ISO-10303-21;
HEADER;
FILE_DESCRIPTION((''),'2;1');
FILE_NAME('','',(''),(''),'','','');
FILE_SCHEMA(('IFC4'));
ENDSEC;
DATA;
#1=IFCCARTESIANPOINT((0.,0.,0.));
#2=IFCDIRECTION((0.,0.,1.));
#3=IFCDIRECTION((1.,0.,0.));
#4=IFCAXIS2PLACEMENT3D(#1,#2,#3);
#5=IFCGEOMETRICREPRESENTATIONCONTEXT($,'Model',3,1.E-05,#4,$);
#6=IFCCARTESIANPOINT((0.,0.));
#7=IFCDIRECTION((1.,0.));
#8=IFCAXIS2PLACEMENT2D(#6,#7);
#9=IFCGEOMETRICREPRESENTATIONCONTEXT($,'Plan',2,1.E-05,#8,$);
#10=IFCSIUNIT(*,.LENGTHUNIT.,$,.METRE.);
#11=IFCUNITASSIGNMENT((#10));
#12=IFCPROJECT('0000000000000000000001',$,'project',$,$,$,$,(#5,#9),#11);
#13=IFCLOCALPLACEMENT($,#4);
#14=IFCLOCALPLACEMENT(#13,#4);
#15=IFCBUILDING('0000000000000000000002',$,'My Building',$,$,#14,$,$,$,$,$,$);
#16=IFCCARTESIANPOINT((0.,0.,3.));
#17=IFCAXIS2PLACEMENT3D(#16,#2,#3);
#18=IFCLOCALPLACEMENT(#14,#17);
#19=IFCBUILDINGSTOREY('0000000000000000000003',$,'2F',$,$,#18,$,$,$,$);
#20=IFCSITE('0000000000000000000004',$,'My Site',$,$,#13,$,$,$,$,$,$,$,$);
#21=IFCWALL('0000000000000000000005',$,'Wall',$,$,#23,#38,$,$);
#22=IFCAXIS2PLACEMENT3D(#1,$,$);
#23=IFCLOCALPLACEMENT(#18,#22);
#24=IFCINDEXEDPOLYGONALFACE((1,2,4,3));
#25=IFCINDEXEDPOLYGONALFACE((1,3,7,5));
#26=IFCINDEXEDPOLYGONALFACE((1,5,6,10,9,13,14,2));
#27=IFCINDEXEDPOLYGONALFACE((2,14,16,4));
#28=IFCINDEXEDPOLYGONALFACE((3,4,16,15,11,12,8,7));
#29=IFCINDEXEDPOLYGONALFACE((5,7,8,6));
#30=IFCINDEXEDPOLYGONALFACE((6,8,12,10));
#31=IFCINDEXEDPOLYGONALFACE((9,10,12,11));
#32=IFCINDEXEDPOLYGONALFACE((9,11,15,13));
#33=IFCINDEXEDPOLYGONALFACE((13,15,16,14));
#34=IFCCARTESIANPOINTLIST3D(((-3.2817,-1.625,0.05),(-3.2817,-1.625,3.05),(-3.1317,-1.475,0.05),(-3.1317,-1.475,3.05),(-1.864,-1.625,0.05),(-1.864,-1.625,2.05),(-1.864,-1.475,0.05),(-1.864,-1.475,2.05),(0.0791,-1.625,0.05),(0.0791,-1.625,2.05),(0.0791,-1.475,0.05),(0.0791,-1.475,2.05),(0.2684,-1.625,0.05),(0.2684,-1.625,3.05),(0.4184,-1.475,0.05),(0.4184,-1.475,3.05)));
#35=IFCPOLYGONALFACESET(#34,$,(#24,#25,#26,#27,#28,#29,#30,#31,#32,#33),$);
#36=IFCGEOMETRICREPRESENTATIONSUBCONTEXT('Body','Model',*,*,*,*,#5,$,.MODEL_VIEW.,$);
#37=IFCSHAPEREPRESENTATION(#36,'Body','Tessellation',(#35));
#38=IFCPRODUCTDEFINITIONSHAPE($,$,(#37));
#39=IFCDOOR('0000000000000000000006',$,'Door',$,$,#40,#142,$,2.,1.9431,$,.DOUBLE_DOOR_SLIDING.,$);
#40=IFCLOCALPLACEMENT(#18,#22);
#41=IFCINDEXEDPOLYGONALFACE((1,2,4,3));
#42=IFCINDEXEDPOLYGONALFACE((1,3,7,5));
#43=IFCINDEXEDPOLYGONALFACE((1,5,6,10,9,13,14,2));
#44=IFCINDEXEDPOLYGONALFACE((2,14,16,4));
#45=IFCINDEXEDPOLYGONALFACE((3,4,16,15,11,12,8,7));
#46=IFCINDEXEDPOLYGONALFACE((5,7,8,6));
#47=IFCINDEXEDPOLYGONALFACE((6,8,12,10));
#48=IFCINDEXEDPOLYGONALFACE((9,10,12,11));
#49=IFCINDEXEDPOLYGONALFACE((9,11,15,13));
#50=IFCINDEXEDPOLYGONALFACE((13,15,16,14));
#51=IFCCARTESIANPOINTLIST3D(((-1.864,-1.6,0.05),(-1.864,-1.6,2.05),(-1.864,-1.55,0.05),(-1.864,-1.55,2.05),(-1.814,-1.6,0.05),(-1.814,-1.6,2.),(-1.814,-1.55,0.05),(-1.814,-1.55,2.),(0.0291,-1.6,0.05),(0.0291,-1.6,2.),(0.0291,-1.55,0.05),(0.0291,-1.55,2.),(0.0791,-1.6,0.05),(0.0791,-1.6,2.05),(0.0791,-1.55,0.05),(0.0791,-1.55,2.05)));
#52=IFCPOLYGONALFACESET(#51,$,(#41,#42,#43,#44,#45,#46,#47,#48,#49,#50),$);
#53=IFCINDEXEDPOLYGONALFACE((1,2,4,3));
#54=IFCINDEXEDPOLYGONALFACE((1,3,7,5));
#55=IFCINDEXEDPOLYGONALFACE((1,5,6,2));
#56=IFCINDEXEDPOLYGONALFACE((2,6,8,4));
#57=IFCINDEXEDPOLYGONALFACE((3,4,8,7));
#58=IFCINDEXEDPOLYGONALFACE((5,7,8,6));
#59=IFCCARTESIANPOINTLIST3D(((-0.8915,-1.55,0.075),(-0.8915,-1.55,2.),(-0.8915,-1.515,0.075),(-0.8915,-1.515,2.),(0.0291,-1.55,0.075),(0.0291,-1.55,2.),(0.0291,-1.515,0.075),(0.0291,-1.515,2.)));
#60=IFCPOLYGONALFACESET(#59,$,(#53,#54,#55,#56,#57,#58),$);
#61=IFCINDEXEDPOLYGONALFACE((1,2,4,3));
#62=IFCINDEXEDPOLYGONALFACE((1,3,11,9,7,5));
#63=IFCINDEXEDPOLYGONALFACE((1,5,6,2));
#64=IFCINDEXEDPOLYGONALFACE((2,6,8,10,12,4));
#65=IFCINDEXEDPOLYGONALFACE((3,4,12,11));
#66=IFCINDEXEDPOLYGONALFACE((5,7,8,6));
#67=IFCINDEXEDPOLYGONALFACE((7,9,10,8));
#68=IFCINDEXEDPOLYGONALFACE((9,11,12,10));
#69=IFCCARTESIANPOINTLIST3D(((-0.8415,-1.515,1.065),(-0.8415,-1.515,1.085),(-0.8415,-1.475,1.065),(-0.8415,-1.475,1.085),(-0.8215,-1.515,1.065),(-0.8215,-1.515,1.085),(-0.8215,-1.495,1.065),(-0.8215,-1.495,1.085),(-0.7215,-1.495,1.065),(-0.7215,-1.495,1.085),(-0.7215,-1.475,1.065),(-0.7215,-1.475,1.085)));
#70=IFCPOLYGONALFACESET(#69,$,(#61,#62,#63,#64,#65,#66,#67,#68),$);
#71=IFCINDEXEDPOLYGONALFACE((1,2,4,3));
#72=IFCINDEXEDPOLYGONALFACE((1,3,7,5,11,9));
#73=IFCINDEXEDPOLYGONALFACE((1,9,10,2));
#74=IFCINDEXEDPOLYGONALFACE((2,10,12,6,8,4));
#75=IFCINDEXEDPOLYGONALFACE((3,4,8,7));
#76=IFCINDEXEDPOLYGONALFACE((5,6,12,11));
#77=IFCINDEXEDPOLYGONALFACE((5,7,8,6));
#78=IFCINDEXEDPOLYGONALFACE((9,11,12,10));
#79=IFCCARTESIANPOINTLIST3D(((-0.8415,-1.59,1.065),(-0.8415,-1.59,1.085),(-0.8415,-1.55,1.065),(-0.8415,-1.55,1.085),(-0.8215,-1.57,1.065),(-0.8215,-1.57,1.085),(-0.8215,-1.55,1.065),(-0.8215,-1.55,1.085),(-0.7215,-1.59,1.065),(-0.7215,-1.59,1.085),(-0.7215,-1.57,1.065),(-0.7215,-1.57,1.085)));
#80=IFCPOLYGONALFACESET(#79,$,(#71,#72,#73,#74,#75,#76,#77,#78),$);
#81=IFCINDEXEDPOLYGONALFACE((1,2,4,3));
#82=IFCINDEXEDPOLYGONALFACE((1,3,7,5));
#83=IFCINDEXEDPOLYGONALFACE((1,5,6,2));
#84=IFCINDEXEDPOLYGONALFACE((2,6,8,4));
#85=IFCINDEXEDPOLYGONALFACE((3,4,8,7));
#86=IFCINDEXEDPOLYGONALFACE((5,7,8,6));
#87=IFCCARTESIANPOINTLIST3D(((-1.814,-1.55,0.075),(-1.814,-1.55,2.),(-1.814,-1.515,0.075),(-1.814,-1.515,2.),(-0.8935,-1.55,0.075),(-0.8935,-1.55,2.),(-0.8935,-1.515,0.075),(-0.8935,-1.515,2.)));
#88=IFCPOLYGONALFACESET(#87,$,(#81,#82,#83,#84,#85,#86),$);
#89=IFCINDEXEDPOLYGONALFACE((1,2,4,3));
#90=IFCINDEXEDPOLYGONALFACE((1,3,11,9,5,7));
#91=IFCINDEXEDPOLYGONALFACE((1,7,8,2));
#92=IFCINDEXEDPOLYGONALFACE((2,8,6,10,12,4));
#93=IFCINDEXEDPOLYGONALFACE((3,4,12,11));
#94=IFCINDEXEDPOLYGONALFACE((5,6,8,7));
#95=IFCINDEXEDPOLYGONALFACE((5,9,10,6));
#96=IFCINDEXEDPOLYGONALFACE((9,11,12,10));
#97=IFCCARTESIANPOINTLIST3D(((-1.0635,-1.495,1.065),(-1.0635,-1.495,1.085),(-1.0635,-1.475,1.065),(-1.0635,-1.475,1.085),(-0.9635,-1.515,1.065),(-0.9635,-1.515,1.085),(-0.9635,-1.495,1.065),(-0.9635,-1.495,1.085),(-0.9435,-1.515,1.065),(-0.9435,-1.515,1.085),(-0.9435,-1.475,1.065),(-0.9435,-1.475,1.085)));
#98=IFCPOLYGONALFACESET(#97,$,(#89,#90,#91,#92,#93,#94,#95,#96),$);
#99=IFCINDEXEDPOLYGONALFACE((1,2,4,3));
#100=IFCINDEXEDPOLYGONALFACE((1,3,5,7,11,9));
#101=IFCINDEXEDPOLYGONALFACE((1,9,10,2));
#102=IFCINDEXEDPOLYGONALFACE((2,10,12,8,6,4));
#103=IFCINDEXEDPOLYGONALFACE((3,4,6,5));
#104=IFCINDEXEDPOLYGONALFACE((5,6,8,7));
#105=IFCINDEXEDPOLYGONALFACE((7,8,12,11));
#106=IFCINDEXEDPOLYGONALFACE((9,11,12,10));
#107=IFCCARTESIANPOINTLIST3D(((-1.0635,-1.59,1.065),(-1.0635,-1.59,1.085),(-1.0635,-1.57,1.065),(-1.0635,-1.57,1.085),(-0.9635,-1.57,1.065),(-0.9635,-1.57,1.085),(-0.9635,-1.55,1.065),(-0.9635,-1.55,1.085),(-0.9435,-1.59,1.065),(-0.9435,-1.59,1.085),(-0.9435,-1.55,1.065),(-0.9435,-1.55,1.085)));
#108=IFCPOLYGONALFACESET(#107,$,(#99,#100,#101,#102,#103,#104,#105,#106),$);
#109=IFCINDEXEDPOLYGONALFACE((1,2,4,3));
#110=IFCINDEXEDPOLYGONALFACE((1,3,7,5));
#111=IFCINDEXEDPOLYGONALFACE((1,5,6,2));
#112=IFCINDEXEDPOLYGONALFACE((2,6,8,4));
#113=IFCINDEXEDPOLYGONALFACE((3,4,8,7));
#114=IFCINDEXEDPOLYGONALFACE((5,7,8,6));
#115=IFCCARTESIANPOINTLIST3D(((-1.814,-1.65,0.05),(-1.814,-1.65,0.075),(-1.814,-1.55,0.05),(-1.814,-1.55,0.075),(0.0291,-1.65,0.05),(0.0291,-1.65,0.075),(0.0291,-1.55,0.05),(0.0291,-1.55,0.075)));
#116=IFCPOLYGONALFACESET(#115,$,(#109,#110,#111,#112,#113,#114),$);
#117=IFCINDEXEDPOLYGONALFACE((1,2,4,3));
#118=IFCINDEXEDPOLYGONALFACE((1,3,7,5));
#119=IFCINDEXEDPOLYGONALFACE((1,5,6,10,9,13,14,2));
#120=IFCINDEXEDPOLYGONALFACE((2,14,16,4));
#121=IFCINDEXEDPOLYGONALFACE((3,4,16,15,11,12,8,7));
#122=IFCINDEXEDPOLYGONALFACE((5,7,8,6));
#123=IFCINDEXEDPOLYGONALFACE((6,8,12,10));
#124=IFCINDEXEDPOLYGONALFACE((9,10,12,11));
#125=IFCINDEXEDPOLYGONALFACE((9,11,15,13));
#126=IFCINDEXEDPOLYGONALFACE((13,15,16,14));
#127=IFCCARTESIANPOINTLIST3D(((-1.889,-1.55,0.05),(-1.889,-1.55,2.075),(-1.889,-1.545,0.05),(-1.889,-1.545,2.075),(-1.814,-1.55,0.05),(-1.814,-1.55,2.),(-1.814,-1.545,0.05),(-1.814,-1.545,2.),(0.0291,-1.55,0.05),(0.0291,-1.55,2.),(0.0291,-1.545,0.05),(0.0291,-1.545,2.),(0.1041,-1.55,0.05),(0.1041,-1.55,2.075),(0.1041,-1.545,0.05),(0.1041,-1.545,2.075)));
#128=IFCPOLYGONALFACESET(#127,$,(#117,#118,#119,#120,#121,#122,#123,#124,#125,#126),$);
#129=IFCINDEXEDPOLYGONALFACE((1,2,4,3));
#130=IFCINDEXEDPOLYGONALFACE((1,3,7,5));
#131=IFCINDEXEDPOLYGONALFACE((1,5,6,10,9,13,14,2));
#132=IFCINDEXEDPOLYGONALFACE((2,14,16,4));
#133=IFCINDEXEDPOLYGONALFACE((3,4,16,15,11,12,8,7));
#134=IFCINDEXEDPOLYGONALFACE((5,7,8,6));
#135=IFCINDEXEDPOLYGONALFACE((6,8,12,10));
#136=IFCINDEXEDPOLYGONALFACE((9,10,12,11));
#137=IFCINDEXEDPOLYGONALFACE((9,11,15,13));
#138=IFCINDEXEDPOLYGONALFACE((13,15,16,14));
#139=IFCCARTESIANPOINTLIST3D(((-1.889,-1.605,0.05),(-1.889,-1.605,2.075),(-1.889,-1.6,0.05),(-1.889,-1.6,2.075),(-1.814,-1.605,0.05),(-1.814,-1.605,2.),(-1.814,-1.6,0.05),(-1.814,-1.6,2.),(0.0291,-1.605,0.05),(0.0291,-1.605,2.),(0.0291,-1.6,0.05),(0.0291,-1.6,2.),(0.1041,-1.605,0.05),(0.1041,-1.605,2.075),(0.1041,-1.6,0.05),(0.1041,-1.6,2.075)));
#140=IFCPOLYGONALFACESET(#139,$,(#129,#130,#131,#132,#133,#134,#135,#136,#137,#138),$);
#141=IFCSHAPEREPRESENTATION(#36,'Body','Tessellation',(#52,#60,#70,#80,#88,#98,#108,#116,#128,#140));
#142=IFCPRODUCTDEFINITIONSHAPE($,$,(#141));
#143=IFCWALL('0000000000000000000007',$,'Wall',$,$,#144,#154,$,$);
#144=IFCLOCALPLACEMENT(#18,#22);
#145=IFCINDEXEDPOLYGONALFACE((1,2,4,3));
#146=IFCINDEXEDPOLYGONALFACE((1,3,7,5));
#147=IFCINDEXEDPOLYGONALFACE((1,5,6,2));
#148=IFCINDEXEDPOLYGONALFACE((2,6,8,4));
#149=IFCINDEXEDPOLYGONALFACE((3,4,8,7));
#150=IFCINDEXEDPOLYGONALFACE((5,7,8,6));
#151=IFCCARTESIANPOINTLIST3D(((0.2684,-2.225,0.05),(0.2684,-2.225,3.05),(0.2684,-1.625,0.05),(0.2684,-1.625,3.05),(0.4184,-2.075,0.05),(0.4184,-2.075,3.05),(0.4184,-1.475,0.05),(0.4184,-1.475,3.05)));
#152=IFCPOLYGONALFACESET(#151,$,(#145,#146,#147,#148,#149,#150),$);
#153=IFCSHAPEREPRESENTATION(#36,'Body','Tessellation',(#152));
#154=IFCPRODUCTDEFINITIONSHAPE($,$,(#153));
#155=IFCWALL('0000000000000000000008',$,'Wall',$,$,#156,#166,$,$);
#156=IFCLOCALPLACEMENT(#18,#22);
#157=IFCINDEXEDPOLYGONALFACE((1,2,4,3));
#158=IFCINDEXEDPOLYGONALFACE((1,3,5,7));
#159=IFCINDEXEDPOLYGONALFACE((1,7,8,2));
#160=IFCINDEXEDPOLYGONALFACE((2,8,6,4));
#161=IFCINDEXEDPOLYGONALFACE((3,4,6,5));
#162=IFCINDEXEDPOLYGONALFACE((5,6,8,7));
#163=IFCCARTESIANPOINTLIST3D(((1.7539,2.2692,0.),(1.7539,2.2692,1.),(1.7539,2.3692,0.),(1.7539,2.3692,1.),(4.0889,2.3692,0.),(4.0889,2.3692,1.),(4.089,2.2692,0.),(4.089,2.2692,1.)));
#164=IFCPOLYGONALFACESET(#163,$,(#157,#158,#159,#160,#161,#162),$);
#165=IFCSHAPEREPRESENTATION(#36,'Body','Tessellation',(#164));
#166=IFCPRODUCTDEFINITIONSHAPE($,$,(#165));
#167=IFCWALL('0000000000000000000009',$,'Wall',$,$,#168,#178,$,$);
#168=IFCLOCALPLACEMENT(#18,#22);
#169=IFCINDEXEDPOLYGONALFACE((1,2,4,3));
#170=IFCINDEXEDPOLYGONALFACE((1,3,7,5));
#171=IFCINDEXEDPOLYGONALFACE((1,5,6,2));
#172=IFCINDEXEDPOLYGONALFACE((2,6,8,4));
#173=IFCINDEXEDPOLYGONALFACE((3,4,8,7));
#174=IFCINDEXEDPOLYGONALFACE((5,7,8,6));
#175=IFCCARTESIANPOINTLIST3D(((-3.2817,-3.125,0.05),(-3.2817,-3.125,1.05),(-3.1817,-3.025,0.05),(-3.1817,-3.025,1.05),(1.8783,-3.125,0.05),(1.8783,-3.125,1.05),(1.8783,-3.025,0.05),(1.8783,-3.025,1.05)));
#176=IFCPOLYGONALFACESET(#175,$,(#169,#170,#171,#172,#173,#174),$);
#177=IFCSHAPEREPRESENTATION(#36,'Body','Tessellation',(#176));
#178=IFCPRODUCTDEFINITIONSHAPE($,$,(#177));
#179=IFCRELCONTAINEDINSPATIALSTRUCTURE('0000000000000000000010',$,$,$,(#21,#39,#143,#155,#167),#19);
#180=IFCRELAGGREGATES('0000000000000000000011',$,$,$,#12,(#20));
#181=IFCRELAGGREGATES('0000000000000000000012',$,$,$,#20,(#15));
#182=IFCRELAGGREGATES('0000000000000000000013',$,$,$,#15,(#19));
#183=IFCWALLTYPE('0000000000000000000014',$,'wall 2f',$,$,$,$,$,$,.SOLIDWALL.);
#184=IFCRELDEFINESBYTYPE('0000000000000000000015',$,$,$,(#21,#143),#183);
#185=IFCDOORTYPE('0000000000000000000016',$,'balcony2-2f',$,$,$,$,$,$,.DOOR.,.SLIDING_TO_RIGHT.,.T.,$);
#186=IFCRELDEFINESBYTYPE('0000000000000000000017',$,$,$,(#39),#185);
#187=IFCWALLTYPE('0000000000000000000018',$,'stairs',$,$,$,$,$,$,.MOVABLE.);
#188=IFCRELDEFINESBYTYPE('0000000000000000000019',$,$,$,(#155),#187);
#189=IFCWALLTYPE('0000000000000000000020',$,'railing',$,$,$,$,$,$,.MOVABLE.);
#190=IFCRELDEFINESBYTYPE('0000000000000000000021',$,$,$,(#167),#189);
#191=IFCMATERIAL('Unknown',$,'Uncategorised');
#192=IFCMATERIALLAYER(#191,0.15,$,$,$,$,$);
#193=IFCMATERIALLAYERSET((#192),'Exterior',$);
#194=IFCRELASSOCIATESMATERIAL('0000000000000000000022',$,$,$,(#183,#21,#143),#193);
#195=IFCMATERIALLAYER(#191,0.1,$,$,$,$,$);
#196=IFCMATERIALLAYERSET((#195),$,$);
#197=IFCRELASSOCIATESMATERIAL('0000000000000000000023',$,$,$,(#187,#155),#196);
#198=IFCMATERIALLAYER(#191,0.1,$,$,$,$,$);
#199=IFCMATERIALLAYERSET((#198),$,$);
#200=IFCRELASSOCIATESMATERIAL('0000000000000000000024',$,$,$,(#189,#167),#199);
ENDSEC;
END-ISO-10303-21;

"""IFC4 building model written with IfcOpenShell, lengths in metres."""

from ifc_helpers import new_model, entity, si_unit, frame, origin_with_axes, origin_2d_with_axis, place, context, subcontext, project, spatial, line, indexed_curve, outline, extrude, shape, source, transform, mapped, material, layer, layer_set, layer_usage, type_object, type_shapes, element, fill, save


model = new_model("IFC4")

# Units and contexts
model_context = context("Model", 3, precision=1e-05, world=origin_with_axes())
plan_context = context("Plan", 2, precision=1e-05, world=origin_2d_with_axis())
body_context_1 = subcontext(model_context, "Body", "Model", "MODEL_VIEW")
body_context_2 = subcontext(plan_context, "Body", "Plan", "PLAN_VIEW")
ifc_project = project(units=[si_unit("LENGTHUNIT", "METRE")], contexts=[model_context, plan_context])

# Site, building, storey
site_placement = place(None, origin_with_axes())
site = spatial("IfcSite", under=ifc_project, at=site_placement, Name="My Site")
building_placement = place(site_placement, origin_with_axes())
building = spatial("IfcBuilding", under=site, at=building_placement, Name="My Building")
storey_placement = place(building_placement, frame((0.0, 0.0, 3.0), z_axis=(0.0, 0.0, 1.0), x_axis=(1.0, 0.0, 0.0)))
storey = spatial("IfcBuildingStorey", under=building, at=storey_placement, Name="2F")

# Shared definitions
ifc_material = material(Name="Unknown", Category="Uncategorised")

# Shared definitions
ifc_layer_1 = layer(ifc_material, 0.15)
ifc_layer_set_1 = layer_set([ifc_layer_1], Name="Exterior")
wall_type_1 = type_object("IfcWallType", Name="wall 2f", PredefinedType="SOLIDWALL", material=ifc_layer_set_1)

# Wall, opening, door
ifc_layer_usage_1 = layer_usage(ifc_layer_set_1, "AXIS2", "POSITIVE", 0.0)
wall_1_placement = place(storey_placement, frame((-3.2817, -1.625, 0.05), z_axis=(0.0, 0.0, 1.0), x_axis=(1.0, 0.0, 0.0)))
wall_1 = element("IfcWall", 1, at=wall_1_placement, inside=storey, type_object=wall_type_1, material=ifc_layer_usage_1, Name="Wall", context=body_context_1, shape_type="SweptSolid", body=[
    extrude(outline(indexed_curve([(0.0, 0.0), (0.15, 0.15), (3.7, 0.15), (3.55, 0.0)], segments=[line(1, 2, 3, 4, 1)])), origin_with_axes(), (0.0, 0.0, 1.0), 3.0),
])
shared_shape_1 = source(origin_with_axes(), body_context_1, "Body", "SweptSolid", [
    extrude(outline(indexed_curve([(0.0, 0.0), (1.9431, 0.0), (1.9431, 2.0), (0.0, 2.0)], segments=[line(1, 2, 3, 4, 1)])), frame((0.0, -0.6, 0.0), z_axis=(0.0, -1.0, 0.0), x_axis=(1.0, 0.0, 0.0)), (0.0, 0.0, -1.0), 1.2),
])
opening_1_placement = place(wall_1_placement, frame((3.3607, 0.075, 0.0), z_axis=(0.0, 0.0, 1.0), x_axis=(-1.0, 0.0, 0.0)))
opening_1 = element("IfcOpeningElement", 2, at=opening_1_placement, cuts=wall_1, PredefinedType="OPENING", context=body_context_1, shape_type="MappedRepresentation", body=[
    mapped(shared_shape_1, transform((0.0, 0.0, 0.0), x_axis=(1.0, 0.0, 0.0), y_axis=(0.0, 1.0, 0.0), z_axis=(0.0, 0.0, 1.0), scale=1.0)),
])
door_type_1 = type_object("IfcDoorType", Name="balcony2-2f", OperationType="SLIDING_TO_RIGHT", ParameterTakesPrecedence=True, PredefinedType="DOOR")
shared_shape_2 = source(origin_with_axes(), body_context_1, "Body", "SweptSolid", [
    extrude(outline(indexed_curve([(0.0, 0.0), (0.0, 2.0), (1.9431, 2.0), (1.9431, 0.0), (1.8931, 0.0), (1.8931, 1.95), (0.05, 1.95), (0.05, 0.0)], segments=[line(1, 2, 3, 4, 5, 6, 7, 8, 1)])), frame((0.0, 0.0, 0.0), z_axis=(0.0, -1.0, 0.0), x_axis=(1.0, 0.0, 0.0)), (0.0, 0.0, -1.0), 0.05),
    extrude(outline(indexed_curve([(0.0, 0.0), (0.9205, 0.0), (0.9205, 0.035), (0.0, 0.035)], segments=[line(1, 2, 3, 4, 1)])), frame((0.05, -0.035, 0.025), z_axis=(0.0, 0.0, 1.0), x_axis=(1.0, 0.0, 0.0)), (0.0, 0.0, 1.0), 1.925),
    extrude(outline(indexed_curve([(0.0, 0.0), (0.0, -0.04), (-0.12, -0.04), (-0.12, -0.02), (-0.02, -0.02), (-0.02, 0.0)], segments=[line(1, 2, 3, 4, 5, 6, 1)])), frame((0.9205, -0.035, 1.015), z_axis=(0.0, 0.0, 1.0), x_axis=(1.0, 0.0, 0.0)), (0.0, 0.0, 1.0), 0.02),
    extrude(outline(indexed_curve([(0.0, 0.0), (0.0, 0.04), (-0.12, 0.04), (-0.12, 0.02), (-0.02, 0.02), (-0.02, 0.0)], segments=[line(1, 2, 3, 4, 5, 6, 1)])), frame((0.9205, 0.0, 1.015), z_axis=(0.0, 0.0, 1.0), x_axis=(1.0, 0.0, 0.0)), (0.0, 0.0, 1.0), 0.02),
    extrude(outline(indexed_curve([(0.0, 0.0), (-0.9205, 0.0), (-0.9205, 0.035), (0.0, 0.035)], segments=[line(1, 2, 3, 4, 1)])), frame((1.8931, -0.035, 0.025), z_axis=(0.0, 0.0, 1.0), x_axis=(1.0, 0.0, 0.0)), (0.0, 0.0, 1.0), 1.925),
    extrude(outline(indexed_curve([(0.0, 0.0), (0.0, -0.04), (0.12, -0.04), (0.12, -0.02), (0.02, -0.02), (0.02, 0.0)], segments=[line(1, 2, 3, 4, 5, 6, 1)])), frame((1.0225, -0.035, 1.015), z_axis=(0.0, 0.0, 1.0), x_axis=(1.0, 0.0, 0.0)), (0.0, 0.0, 1.0), 0.02),
    extrude(outline(indexed_curve([(0.0, 0.0), (0.0, 0.04), (0.12, 0.04), (0.12, 0.02), (0.02, 0.02), (0.02, 0.0)], segments=[line(1, 2, 3, 4, 5, 6, 1)])), frame((1.0225, 0.0, 1.015), z_axis=(0.0, 0.0, 1.0), x_axis=(1.0, 0.0, 0.0)), (0.0, 0.0, 1.0), 0.02),
    extrude(outline(indexed_curve([(0.0, 0.0), (1.8431, 0.0), (1.8431, 0.1), (0.0, 0.1)], segments=[line(1, 2, 3, 4, 1)])), frame((0.05, 0.0, 0.0), z_axis=(0.0, 0.0, 1.0), x_axis=(1.0, 0.0, 0.0)), (0.0, 0.0, 1.0), 0.025),
    extrude(outline(indexed_curve([(0.0, 0.0), (0.0, 2.025), (1.9931, 2.025), (1.9931, 0.0), (1.9181, 0.0), (1.9181, 1.95), (0.075, 1.95), (0.075, 0.0)], segments=[line(1, 2, 3, 4, 5, 6, 7, 8, 1)])), frame((-0.025, -0.005, 0.0), z_axis=(0.0, -1.0, 0.0), x_axis=(1.0, 0.0, 0.0)), (0.0, 0.0, -1.0), 0.005),
    extrude(outline(indexed_curve([(0.0, 0.0), (0.0, 2.025), (1.9931, 2.025), (1.9931, 0.0), (1.9181, 0.0), (1.9181, 1.95), (0.075, 1.95), (0.075, 0.0)], segments=[line(1, 2, 3, 4, 5, 6, 7, 8, 1)])), frame((-0.025, 0.05, 0.0), z_axis=(0.0, -1.0, 0.0), x_axis=(1.0, 0.0, 0.0)), (0.0, 0.0, -1.0), 0.005),
])
shared_shape_3 = source(origin_with_axes(), body_context_2, "Body", "Curve2D", [
    entity("IfcIndexedPolyCurve", entity("IfcCartesianPointList2D", [[0.0, 0.0], [0.05, 0.0], [0.05, 0.05], [0.0, 0.05]]), [entity("IfcLineIndex", [1, 2, 3, 4, 1])]),
    entity("IfcIndexedPolyCurve", entity("IfcCartesianPointList2D", [[1.9431, 0.0], [1.8931, 0.0], [1.8931, 0.05], [1.9431, 0.05]]), [entity("IfcLineIndex", [1, 2, 3, 4, 1])]),
    entity("IfcIndexedPolyCurve", entity("IfcCartesianPointList2D", [[-0.4108, -0.035], [0.5108, -0.035], [0.5108, 0.0], [-0.4108, 0.0]]), [entity("IfcLineIndex", [1, 2, 3, 4, 1])]),
    entity("IfcIndexedPolyCurve", entity("IfcCartesianPointList2D", [[2.3538, -0.035], [1.4323, -0.035], [1.4323, 0.0], [2.3538, 0.0]]), [entity("IfcLineIndex", [1, 2, 3, 4, 1])]),
])
type_shapes(door_type_1, [shared_shape_2, shared_shape_3])
door_1_placement = place(opening_1_placement, origin_with_axes())
door_1 = element("IfcDoor", 3, at=door_1_placement, inside=storey, type_object=door_type_1, Name="Door", OperationType="DOUBLE_DOOR_SLIDING", OverallHeight=2.0, OverallWidth=1.9431, shapes=[
    shape(body_context_1, "Body", "MappedRepresentation", [mapped(shared_shape_2, transform((0.0, 0.0, 0.0), x_axis=(1.0, 0.0, 0.0), y_axis=(0.0, 1.0, 0.0), z_axis=(0.0, 0.0, 1.0), scale=1.0))]),
    shape(body_context_2, "Body", "MappedRepresentation", [mapped(shared_shape_3, transform((0.0, 0.0, 0.0), x_axis=(1.0, 0.0, 0.0), y_axis=(0.0, 1.0, 0.0), z_axis=(0.0, 0.0, 1.0), scale=1.0))]),
])
fill(opening_1, door_1)

# Walls
ifc_layer_usage_2 = layer_usage(ifc_layer_set_1, "AXIS2", "POSITIVE", 0.0)
wall_2_placement = place(storey_placement, frame((0.2684, -1.625, 0.05), z_axis=(0.0, 0.0, 1.0), x_axis=(0.0, -1.0, 0.0)))
element("IfcWall", 4, at=wall_2_placement, inside=storey, type_object=wall_type_1, material=ifc_layer_usage_2, Name="Wall", context=body_context_1, shape_type="SweptSolid", body=[
    extrude(outline(indexed_curve([(0.0, 0.0), (-0.15, 0.15), (0.45, 0.15), (0.6, 0.0)], segments=[line(1, 2, 3, 4, 1)])), origin_with_axes(), (0.0, 0.0, 1.0), 3.0),
])
ifc_layer_2 = layer(ifc_material, 0.1)
ifc_layer_set_2 = layer_set([ifc_layer_2])
ifc_layer_usage_3 = layer_usage(ifc_layer_set_2, "AXIS2", "POSITIVE", 0.0)
wall_type_2 = type_object("IfcWallType", Name="stairs", PredefinedType="MOVABLE", material=ifc_layer_set_2)
wall_3_placement = place(storey_placement, frame((1.7539, 2.2692, 0.0), z_axis=(0.0, 0.0, 1.0), x_axis=(1.0, 0.0, 0.0)))
element("IfcWall", 5, at=wall_3_placement, inside=storey, type_object=wall_type_2, material=ifc_layer_usage_3, Name="Wall", context=body_context_1, shape_type="SweptSolid", body=[
    extrude(outline(indexed_curve([(0.0, 0.0), (0.0, 0.1), (2.3351, 0.1), (2.3351, 0.0)], segments=[line(1, 2, 3, 4, 1)])), origin_with_axes(), (0.0, 0.0, 1.0), 1.0),
])
ifc_layer_3 = layer(ifc_material, 0.1)
ifc_layer_set_3 = layer_set([ifc_layer_3])
ifc_layer_usage_4 = layer_usage(ifc_layer_set_3, "AXIS2", "POSITIVE", 0.0)
wall_type_3 = type_object("IfcWallType", Name="railing", PredefinedType="MOVABLE", material=ifc_layer_set_3)
wall_4_placement = place(storey_placement, frame((1.8783, -3.025, 0.05), z_axis=(0.0, 0.0, 1.0), x_axis=(-1.0, 0.0, 0.0)))
element("IfcWall", 6, at=wall_4_placement, inside=storey, type_object=wall_type_3, material=ifc_layer_usage_4, Name="Wall", context=body_context_1, shape_type="SweptSolid", body=[
    extrude(outline(indexed_curve([(0.0, 0.0), (0.0, 0.1), (5.16, 0.1), (5.06, 0.0)], segments=[line(1, 2, 3, 4, 1)])), origin_with_axes(), (0.0, 0.0, 1.0), 1.0),
])

save(model, "model.ifc")
